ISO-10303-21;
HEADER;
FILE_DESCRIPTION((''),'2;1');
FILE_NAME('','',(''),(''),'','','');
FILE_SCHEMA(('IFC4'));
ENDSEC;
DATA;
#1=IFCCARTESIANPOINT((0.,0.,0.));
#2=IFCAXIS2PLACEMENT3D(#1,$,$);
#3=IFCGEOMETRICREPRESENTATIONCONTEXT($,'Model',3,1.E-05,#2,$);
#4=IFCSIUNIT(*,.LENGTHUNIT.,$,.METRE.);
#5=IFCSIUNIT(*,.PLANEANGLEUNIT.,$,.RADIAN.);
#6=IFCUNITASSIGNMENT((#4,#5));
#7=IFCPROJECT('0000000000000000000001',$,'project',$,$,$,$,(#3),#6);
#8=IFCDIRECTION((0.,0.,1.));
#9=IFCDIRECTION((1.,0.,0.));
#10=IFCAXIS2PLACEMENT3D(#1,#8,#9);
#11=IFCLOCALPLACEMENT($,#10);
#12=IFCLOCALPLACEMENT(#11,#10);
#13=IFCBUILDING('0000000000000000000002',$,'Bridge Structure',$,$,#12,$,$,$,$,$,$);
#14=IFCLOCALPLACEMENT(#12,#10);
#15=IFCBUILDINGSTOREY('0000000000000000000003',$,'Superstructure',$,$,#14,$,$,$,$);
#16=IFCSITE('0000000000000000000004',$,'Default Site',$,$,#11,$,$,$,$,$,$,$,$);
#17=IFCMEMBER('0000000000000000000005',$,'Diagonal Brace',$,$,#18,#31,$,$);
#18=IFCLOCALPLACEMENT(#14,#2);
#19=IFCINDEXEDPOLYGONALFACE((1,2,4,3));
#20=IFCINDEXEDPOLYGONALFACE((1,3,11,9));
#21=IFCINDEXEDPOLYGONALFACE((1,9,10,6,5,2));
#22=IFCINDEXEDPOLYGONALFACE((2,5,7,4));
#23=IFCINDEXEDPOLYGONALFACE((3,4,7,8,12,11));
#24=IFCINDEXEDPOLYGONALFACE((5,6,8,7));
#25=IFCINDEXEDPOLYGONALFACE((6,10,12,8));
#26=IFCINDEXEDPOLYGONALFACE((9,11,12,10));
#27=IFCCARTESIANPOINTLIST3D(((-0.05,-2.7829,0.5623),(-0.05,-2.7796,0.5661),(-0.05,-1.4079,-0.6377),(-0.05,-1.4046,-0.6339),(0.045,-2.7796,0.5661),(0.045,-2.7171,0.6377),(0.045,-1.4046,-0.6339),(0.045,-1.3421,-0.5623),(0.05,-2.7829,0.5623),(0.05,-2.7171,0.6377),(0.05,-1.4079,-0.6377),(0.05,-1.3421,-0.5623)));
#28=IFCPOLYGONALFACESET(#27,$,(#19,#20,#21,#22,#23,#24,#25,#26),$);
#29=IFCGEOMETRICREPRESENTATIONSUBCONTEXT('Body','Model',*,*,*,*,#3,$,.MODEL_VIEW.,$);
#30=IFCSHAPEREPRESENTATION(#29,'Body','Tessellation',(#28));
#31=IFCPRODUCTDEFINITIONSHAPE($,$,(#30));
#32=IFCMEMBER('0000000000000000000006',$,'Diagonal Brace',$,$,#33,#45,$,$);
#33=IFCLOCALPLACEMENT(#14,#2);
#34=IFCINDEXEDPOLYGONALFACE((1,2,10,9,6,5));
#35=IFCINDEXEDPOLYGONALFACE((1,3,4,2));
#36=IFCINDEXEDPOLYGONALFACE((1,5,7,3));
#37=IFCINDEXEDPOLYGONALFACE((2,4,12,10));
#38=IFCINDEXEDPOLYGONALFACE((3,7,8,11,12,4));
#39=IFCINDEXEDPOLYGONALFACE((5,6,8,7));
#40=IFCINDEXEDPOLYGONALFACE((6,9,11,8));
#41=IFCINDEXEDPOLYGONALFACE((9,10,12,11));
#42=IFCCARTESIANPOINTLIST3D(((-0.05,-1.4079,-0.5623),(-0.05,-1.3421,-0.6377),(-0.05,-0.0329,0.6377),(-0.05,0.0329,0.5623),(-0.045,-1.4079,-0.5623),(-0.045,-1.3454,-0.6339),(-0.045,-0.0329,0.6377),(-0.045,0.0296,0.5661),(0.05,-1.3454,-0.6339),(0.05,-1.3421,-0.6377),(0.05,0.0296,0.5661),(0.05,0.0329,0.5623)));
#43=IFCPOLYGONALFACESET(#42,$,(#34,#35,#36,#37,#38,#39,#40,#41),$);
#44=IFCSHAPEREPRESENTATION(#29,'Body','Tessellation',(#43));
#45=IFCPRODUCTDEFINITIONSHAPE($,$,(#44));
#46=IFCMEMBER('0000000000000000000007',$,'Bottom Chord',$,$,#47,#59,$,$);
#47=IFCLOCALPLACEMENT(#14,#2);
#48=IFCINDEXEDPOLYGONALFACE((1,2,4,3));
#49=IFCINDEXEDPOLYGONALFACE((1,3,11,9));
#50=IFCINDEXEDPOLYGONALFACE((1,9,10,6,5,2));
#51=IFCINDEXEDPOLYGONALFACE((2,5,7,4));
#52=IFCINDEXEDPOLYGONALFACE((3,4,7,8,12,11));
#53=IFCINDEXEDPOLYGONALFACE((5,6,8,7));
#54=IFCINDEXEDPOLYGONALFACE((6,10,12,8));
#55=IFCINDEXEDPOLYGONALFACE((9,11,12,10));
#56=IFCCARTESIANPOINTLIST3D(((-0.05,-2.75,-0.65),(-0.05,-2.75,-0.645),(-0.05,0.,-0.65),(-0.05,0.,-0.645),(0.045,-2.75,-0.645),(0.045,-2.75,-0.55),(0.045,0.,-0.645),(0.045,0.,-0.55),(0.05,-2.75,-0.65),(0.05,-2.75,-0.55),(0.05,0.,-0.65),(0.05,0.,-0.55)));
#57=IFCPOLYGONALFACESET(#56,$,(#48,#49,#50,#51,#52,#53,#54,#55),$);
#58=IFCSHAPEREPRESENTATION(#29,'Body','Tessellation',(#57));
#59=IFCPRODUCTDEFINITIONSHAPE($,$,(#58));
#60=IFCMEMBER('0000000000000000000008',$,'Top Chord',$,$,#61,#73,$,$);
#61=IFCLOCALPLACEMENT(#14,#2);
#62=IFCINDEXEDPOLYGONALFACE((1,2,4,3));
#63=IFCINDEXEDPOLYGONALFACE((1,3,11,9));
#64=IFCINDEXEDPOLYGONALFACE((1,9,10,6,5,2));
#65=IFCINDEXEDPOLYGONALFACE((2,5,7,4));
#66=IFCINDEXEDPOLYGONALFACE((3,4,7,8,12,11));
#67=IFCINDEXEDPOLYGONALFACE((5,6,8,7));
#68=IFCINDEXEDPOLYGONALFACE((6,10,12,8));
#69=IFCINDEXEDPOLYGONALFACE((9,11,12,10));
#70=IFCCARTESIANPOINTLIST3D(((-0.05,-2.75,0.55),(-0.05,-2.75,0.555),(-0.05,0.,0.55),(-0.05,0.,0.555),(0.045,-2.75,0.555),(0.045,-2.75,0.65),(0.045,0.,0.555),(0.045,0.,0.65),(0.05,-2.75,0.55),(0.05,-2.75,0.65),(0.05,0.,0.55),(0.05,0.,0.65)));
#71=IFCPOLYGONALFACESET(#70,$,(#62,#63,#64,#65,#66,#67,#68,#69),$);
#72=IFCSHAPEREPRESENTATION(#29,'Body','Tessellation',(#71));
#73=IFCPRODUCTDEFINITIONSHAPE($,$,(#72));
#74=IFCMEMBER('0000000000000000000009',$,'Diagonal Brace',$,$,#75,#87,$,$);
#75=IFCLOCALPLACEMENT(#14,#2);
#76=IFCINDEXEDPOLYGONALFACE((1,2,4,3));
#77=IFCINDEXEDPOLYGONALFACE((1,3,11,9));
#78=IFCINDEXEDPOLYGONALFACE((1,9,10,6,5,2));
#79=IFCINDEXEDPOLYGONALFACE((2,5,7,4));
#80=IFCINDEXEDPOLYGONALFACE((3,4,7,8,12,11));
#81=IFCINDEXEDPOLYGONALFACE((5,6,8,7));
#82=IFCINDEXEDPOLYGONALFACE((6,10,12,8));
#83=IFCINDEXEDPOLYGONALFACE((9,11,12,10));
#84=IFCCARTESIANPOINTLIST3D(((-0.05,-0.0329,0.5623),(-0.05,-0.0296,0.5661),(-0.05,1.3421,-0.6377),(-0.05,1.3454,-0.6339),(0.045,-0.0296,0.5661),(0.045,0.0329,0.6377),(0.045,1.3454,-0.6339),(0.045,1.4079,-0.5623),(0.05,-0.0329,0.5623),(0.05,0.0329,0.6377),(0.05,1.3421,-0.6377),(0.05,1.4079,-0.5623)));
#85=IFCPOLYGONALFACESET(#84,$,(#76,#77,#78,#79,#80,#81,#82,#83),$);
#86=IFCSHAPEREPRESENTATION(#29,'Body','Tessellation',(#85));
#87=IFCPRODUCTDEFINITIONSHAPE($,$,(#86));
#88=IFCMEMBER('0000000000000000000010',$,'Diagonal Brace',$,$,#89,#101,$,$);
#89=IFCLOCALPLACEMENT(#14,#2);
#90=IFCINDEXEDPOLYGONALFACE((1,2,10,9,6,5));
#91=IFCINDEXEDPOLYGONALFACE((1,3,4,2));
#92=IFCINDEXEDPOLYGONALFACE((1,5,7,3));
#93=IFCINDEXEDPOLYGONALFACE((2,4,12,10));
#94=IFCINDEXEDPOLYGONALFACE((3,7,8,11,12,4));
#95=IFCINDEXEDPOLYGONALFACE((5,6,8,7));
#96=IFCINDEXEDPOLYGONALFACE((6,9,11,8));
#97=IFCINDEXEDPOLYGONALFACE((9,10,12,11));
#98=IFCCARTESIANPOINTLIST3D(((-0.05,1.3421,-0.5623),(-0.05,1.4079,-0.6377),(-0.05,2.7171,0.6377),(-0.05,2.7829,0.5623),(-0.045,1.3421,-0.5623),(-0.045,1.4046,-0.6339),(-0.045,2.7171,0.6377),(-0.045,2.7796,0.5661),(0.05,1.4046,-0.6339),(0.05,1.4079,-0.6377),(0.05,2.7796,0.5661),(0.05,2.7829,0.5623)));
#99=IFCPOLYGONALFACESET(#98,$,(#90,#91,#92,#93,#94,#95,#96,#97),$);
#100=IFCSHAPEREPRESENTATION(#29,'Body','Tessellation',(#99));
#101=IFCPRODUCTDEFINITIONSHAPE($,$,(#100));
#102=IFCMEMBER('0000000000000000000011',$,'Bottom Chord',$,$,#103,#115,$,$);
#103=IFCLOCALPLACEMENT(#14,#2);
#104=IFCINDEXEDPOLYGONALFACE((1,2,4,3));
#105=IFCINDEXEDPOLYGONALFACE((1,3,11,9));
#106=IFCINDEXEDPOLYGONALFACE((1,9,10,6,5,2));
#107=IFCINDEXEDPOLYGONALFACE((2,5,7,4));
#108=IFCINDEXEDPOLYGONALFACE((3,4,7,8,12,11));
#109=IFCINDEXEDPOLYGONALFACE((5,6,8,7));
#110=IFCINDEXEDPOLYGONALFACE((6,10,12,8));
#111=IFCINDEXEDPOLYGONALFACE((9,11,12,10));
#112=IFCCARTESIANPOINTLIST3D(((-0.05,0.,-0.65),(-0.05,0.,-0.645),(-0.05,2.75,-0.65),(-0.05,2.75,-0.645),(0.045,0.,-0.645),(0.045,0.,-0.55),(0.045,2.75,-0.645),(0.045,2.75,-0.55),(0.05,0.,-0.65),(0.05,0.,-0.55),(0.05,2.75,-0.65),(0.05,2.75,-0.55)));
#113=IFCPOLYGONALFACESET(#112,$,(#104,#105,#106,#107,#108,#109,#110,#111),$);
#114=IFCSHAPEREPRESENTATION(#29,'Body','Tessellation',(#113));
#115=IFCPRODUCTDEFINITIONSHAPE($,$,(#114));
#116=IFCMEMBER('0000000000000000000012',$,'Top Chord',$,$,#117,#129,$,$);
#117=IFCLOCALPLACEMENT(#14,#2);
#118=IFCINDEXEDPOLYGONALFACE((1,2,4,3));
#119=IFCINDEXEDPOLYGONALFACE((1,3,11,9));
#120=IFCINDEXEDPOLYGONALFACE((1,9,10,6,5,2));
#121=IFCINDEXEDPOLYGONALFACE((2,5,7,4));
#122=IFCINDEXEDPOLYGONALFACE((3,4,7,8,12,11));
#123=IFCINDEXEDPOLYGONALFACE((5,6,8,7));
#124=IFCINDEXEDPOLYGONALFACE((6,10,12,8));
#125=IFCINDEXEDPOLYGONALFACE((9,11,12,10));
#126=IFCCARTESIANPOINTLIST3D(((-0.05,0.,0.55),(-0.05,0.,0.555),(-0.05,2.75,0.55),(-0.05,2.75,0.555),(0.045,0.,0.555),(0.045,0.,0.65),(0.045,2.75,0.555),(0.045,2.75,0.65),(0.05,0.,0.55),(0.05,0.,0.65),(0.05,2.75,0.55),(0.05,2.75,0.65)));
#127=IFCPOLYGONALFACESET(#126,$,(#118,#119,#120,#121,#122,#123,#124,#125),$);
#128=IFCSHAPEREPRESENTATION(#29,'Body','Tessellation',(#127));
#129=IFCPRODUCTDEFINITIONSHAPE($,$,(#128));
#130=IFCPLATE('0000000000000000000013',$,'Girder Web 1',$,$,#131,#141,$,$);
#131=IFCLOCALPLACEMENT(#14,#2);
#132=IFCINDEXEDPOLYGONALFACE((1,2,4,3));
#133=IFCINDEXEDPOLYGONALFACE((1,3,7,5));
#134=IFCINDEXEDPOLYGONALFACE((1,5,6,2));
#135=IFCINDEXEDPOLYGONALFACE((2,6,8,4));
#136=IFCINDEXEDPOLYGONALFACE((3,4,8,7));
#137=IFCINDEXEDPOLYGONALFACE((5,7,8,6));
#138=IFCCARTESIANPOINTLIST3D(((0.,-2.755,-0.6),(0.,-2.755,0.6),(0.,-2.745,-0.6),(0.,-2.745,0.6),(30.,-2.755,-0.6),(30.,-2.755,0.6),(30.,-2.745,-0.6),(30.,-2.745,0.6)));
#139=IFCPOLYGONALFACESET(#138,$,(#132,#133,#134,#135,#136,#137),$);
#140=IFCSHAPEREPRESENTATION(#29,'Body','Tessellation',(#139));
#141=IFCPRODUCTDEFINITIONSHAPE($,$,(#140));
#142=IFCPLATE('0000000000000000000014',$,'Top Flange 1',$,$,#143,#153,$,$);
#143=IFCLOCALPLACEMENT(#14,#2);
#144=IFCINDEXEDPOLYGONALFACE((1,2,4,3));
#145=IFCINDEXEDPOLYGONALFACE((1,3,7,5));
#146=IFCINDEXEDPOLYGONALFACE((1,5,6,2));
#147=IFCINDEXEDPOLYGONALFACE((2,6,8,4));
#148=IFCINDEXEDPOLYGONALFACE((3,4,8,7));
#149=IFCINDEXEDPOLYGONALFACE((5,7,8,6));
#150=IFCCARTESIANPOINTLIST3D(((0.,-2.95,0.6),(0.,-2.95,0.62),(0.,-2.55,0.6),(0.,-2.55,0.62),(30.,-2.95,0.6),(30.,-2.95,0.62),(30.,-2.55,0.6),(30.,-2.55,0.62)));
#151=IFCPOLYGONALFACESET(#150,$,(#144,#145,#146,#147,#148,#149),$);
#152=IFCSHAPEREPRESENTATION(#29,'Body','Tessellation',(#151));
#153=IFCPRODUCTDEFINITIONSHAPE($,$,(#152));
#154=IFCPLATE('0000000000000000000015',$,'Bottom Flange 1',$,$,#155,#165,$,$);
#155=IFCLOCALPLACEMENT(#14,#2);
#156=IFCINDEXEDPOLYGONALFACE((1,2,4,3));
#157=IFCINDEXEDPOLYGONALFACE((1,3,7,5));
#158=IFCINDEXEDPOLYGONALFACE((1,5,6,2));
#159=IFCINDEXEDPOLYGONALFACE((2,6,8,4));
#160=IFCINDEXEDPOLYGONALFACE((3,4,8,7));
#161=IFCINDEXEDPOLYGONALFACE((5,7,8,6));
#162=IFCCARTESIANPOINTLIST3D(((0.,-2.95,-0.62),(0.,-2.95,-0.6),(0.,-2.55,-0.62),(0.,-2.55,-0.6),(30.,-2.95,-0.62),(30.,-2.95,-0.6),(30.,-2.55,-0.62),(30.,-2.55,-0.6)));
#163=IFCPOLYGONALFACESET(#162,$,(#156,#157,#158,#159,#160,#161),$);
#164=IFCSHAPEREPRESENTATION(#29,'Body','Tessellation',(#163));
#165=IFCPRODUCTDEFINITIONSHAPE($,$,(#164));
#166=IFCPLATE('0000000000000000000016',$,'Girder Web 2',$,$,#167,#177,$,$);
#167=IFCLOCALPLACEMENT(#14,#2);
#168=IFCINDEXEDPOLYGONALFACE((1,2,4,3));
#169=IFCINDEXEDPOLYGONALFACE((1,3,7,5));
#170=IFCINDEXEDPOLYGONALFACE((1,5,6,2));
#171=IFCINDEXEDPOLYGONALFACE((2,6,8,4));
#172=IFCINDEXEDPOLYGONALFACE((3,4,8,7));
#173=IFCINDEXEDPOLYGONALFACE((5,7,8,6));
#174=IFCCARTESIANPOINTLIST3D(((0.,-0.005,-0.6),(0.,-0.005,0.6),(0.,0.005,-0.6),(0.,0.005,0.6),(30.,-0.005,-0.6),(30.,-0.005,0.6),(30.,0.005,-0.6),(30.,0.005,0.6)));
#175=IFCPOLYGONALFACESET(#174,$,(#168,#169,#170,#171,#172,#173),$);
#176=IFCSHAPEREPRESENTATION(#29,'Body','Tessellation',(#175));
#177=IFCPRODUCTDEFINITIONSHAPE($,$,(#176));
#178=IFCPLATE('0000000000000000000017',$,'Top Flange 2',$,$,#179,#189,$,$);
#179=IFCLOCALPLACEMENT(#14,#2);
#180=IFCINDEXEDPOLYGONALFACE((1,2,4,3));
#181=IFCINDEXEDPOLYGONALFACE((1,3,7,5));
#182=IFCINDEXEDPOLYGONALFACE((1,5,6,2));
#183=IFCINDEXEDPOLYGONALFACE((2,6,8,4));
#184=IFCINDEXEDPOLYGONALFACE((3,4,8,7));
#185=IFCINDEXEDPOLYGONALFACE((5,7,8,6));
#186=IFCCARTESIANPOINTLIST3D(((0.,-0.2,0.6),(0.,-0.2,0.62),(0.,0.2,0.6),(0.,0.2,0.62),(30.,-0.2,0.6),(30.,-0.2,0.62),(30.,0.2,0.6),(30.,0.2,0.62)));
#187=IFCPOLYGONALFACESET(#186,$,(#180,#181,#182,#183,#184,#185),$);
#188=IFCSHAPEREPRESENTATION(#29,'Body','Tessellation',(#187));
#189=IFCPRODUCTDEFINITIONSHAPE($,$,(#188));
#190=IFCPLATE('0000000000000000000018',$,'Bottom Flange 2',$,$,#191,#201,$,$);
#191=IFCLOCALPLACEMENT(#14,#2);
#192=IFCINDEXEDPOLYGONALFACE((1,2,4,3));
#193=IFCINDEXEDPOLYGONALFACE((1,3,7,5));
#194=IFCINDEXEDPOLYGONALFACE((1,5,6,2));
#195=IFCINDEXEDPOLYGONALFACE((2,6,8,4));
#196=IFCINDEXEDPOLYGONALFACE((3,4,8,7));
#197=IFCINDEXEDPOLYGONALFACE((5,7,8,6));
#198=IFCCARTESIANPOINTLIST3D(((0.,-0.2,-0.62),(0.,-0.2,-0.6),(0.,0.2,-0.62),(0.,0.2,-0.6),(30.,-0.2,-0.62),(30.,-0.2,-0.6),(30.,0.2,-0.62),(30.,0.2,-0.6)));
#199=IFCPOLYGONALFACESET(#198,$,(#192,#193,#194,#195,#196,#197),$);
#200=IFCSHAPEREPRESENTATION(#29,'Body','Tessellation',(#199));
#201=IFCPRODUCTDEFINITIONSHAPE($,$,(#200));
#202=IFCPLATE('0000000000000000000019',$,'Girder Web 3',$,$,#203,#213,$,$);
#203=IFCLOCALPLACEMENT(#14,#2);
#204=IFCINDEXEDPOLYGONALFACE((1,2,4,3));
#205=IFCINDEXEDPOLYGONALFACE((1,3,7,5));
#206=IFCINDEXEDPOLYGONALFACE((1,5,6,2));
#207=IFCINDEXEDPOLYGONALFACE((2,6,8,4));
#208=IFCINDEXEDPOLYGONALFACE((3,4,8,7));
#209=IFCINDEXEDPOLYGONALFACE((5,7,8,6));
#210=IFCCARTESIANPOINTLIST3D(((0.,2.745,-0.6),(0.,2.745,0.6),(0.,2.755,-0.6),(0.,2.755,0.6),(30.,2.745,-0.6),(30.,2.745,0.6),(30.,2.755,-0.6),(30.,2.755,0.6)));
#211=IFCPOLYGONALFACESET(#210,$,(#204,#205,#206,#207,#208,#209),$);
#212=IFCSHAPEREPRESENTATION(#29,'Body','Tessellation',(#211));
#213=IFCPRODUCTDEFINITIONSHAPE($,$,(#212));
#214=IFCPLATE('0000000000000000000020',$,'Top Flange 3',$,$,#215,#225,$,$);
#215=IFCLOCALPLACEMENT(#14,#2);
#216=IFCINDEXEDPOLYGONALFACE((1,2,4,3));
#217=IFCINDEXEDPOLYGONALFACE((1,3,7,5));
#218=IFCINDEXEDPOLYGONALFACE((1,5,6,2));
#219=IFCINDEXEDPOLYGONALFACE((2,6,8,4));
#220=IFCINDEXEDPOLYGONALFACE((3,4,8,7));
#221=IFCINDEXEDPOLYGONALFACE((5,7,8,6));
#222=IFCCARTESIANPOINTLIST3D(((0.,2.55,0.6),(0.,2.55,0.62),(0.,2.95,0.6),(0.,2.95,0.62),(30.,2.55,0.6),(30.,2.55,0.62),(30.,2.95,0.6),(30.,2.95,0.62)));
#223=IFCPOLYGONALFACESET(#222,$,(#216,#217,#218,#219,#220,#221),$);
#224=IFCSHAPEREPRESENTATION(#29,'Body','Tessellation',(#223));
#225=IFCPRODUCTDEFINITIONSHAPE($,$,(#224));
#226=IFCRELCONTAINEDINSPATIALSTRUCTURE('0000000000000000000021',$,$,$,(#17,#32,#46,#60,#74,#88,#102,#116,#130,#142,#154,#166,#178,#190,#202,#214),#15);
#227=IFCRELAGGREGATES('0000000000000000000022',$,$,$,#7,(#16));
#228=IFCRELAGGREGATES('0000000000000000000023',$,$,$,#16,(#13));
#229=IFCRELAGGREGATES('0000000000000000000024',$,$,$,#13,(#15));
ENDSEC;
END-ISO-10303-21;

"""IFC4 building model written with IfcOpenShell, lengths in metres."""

from ifc_helpers import new_model, si_unit, frame, origin, origin_with_axes, origin_2d_with_axis, place, context, subcontext, project, spatial, rectangle, l_section, extrude, element, save


model = new_model("IFC4")

# Units and contexts
model_context = context("Model", 3, precision=1e-05, world=origin())
body_context = subcontext(model_context, "Body", "Model", "MODEL_VIEW")
ifc_project = project(units=[si_unit("LENGTHUNIT", "METRE"), si_unit("PLANEANGLEUNIT", "RADIAN")], contexts=[model_context])

# Site, building, storey
site_placement = place(None, origin_with_axes())
site = spatial("IfcSite", under=ifc_project, at=site_placement, Name="Default Site")
building_placement = place(site_placement, origin_with_axes())
building = spatial("IfcBuilding", under=site, at=building_placement, Name="Bridge Structure")
storey_placement = place(building_placement, origin_with_axes())
storey = spatial("IfcBuildingStorey", under=building, at=storey_placement, Name="Superstructure")

# Members
for number, where, z_axis, x_axis, name in (
    (1, (0.0, -2.75, 0.6), (0.0, 0.753425, -0.657534), (-1.0, 0.0, 0.0), "Diagonal Brace"),
    (2, (0.0, 0.0, 0.6), (0.0, -0.753425, -0.657534), (1.0, 0.0, 0.0), "Diagonal Brace"),
):
    element("IfcMember", number, at=place(storey_placement, frame(where, z_axis=z_axis, x_axis=x_axis)), inside=storey, Name=name, context=body_context, shape_type="SweptSolid", body=[
        extrude(l_section(Depth=0.1, Width=0.1, Thickness=0.005, at=origin_2d_with_axis()), origin_with_axes(), (0.0, 0.0, 1.0), 1.825),
    ])
for number, where, z_axis, x_axis, name in (
    (3, (0.0, -2.75, -0.6), (0.0, 1.0, 0.0), (-1.0, 0.0, 0.0), "Bottom Chord"),
    (4, (0.0, -2.75, 0.6), (0.0, 1.0, 0.0), (-1.0, 0.0, 0.0), "Top Chord"),
):
    element("IfcMember", number, at=place(storey_placement, frame(where, z_axis=z_axis, x_axis=x_axis)), inside=storey, Name=name, context=body_context, shape_type="SweptSolid", body=[
        extrude(l_section(Depth=0.1, Width=0.1, Thickness=0.005, at=origin_2d_with_axis()), origin_with_axes(), (0.0, 0.0, 1.0), 2.75),
    ])
for number, where, z_axis, x_axis, name in (
    (5, (0.0, 0.0, 0.6), (0.0, 0.753425, -0.657534), (-1.0, 0.0, 0.0), "Diagonal Brace"),
    (6, (0.0, 2.75, 0.6), (0.0, -0.753425, -0.657534), (1.0, 0.0, 0.0), "Diagonal Brace"),
):
    element("IfcMember", number, at=place(storey_placement, frame(where, z_axis=z_axis, x_axis=x_axis)), inside=storey, Name=name, context=body_context, shape_type="SweptSolid", body=[
        extrude(l_section(Depth=0.1, Width=0.1, Thickness=0.005, at=origin_2d_with_axis()), origin_with_axes(), (0.0, 0.0, 1.0), 1.825),
    ])
for number, where, z_axis, x_axis, name in (
    (7, (0.0, 0.0, -0.6), (0.0, 1.0, 0.0), (-1.0, 0.0, 0.0), "Bottom Chord"),
    (8, (0.0, 0.0, 0.6), (0.0, 1.0, 0.0), (-1.0, 0.0, 0.0), "Top Chord"),
):
    element("IfcMember", number, at=place(storey_placement, frame(where, z_axis=z_axis, x_axis=x_axis)), inside=storey, Name=name, context=body_context, shape_type="SweptSolid", body=[
        extrude(l_section(Depth=0.1, Width=0.1, Thickness=0.005, at=origin_2d_with_axis()), origin_with_axes(), (0.0, 0.0, 1.0), 2.75),
    ])

# Plates
plate_1_placement = place(storey_placement, frame((0.0, -2.75, 0.0), z_axis=(1.0, 0.0, 0.0), x_axis=(0.0, 1.0, 0.0)))
element("IfcPlate", 9, at=plate_1_placement, inside=storey, Name="Girder Web 1", context=body_context, shape_type="SweptSolid", body=[
    extrude(rectangle(XDim=0.01, YDim=1.2, at=origin_2d_with_axis()), origin_with_axes(), (0.0, 0.0, 1.0), 30.0),
])
for number, where, z_axis, x_axis, name in (
    (10, (0.0, -2.75, 0.61), (1.0, 0.0, 0.0), (0.0, 1.0, 0.0), "Top Flange 1"),
    (11, (0.0, -2.75, -0.61), (1.0, 0.0, 0.0), (0.0, 1.0, 0.0), "Bottom Flange 1"),
):
    element("IfcPlate", number, at=place(storey_placement, frame(where, z_axis=z_axis, x_axis=x_axis)), inside=storey, Name=name, context=body_context, shape_type="SweptSolid", body=[
        extrude(rectangle(XDim=0.4, YDim=0.02, at=origin_2d_with_axis()), origin_with_axes(), (0.0, 0.0, 1.0), 30.0),
    ])
plate_2_placement = place(storey_placement, frame((0.0, 0.0, 0.0), z_axis=(1.0, 0.0, 0.0), x_axis=(0.0, 1.0, 0.0)))
element("IfcPlate", 12, at=plate_2_placement, inside=storey, Name="Girder Web 2", context=body_context, shape_type="SweptSolid", body=[
    extrude(rectangle(XDim=0.01, YDim=1.2, at=origin_2d_with_axis()), origin_with_axes(), (0.0, 0.0, 1.0), 30.0),
])
for number, where, z_axis, x_axis, name in (
    (13, (0.0, 0.0, 0.61), (1.0, 0.0, 0.0), (0.0, 1.0, 0.0), "Top Flange 2"),
    (14, (0.0, 0.0, -0.61), (1.0, 0.0, 0.0), (0.0, 1.0, 0.0), "Bottom Flange 2"),
):
    element("IfcPlate", number, at=place(storey_placement, frame(where, z_axis=z_axis, x_axis=x_axis)), inside=storey, Name=name, context=body_context, shape_type="SweptSolid", body=[
        extrude(rectangle(XDim=0.4, YDim=0.02, at=origin_2d_with_axis()), origin_with_axes(), (0.0, 0.0, 1.0), 30.0),
    ])
plate_3_placement = place(storey_placement, frame((0.0, 2.75, 0.0), z_axis=(1.0, 0.0, 0.0), x_axis=(0.0, 1.0, 0.0)))
element("IfcPlate", 15, at=plate_3_placement, inside=storey, Name="Girder Web 3", context=body_context, shape_type="SweptSolid", body=[
    extrude(rectangle(XDim=0.01, YDim=1.2, at=origin_2d_with_axis()), origin_with_axes(), (0.0, 0.0, 1.0), 30.0),
])
for number, where, z_axis, x_axis, name in (
    (16, (0.0, 2.75, 0.61), (1.0, 0.0, 0.0), (0.0, 1.0, 0.0), "Top Flange 3"),
):
    element("IfcPlate", number, at=place(storey_placement, frame(where, z_axis=z_axis, x_axis=x_axis)), inside=storey, Name=name, context=body_context, shape_type="SweptSolid", body=[
        extrude(rectangle(XDim=0.4, YDim=0.02, at=origin_2d_with_axis()), origin_with_axes(), (0.0, 0.0, 1.0), 30.0),
    ])

save(model, "model.ifc")
